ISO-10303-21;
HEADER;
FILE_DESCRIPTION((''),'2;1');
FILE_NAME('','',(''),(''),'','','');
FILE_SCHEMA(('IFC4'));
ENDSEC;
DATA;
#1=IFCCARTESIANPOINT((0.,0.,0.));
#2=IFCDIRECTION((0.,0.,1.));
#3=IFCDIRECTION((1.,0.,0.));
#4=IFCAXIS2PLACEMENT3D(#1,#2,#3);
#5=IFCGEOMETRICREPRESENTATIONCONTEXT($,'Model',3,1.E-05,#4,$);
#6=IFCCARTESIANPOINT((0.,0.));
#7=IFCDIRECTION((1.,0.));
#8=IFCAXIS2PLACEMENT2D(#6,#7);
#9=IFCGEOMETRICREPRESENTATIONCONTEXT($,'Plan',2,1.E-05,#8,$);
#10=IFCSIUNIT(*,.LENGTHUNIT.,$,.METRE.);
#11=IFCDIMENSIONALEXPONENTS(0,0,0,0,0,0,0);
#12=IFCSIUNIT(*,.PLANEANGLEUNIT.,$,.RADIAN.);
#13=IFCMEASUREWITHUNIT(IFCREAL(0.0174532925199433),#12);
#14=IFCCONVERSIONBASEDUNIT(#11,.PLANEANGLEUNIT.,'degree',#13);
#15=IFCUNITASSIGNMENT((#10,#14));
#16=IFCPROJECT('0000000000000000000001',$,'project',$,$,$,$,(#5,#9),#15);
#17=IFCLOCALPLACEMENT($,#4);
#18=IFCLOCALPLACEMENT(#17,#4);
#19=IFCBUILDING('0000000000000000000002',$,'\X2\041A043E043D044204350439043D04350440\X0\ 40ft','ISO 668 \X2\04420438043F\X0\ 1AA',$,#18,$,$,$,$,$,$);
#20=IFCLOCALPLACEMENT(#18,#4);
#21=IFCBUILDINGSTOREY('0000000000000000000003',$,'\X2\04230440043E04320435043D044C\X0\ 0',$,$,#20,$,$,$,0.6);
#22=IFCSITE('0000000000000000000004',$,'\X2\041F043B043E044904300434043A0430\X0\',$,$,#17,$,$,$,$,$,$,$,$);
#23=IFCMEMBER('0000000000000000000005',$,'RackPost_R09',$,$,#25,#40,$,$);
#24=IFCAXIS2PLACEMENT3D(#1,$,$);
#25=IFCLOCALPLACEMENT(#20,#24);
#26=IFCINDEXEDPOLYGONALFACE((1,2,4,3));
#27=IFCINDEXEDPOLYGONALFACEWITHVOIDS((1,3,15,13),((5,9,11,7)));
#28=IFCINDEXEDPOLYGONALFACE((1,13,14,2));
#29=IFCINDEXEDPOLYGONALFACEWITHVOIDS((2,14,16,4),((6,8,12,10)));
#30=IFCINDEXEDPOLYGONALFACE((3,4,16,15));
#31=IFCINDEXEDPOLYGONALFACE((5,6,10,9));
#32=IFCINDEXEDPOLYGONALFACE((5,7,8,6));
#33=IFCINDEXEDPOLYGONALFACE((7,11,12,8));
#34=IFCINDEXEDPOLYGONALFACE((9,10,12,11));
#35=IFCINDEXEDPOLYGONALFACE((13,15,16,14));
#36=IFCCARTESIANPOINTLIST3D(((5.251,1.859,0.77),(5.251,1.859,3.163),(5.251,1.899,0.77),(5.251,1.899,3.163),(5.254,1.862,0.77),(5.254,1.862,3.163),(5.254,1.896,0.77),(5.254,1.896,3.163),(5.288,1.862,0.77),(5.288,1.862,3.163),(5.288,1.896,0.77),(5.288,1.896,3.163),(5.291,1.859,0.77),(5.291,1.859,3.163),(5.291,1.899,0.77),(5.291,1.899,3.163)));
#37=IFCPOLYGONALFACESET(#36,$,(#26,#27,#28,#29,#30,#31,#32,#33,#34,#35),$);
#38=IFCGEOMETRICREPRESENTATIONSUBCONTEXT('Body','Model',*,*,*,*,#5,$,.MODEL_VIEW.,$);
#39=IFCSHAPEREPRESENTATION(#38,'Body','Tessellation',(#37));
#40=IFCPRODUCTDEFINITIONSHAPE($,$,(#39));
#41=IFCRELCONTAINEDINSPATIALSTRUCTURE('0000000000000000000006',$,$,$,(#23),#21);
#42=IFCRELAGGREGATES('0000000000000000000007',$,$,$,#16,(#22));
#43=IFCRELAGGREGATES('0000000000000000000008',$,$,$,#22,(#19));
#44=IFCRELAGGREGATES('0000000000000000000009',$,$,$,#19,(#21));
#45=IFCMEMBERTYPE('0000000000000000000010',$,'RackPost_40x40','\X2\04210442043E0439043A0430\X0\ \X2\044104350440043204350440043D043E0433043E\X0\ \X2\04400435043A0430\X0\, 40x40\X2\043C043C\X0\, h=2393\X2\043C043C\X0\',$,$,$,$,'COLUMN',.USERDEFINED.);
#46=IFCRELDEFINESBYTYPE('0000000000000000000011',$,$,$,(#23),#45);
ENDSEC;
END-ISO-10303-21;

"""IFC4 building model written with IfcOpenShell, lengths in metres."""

from ifc_helpers import new_model, entity, si_unit, converted_unit, frame, origin_with_axes, origin_2d_with_axis, place, context, subcontext, project, spatial, hollow_rectangle, extrude, type_object, element, save


model = new_model("IFC4")

# Units and contexts
model_context = context("Model", 3, precision=1e-05, world=origin_with_axes())
plan_context = context("Plan", 2, precision=1e-05, world=origin_2d_with_axis())
body_context = subcontext(model_context, "Body", "Model", "MODEL_VIEW")
ifc_project = project(units=[si_unit("LENGTHUNIT", "METRE"), converted_unit("PLANEANGLEUNIT", "degree", entity("IfcReal", 0.0174532925199433), si_unit("PLANEANGLEUNIT", "RADIAN"), dimensions=[0, 0, 0, 0, 0, 0, 0])], contexts=[model_context, plan_context])

# Site, building, storey
site_placement = place(None, origin_with_axes())
site = spatial("IfcSite", under=ifc_project, at=site_placement, Name="Площадка")
building_placement = place(site_placement, origin_with_axes())
building = spatial("IfcBuilding", under=site, at=building_placement, Name="Контейнер 40ft", Description="ISO 668 тип 1AA")
storey_placement = place(building_placement, origin_with_axes())
storey = spatial("IfcBuildingStorey", under=building, at=storey_placement, Name="Уровень 0", Elevation=0.6)

# Member
member_type = type_object("IfcMemberType", Name="RackPost_40x40", Description="Стойка серверного река, 40x40мм, h=2393мм", ElementType="COLUMN", PredefinedType="USERDEFINED")
for number, where, z_axis, x_axis, name in (
    (1, (5.271, 1.879, 0.77), (0.0, 0.0, 1.0), (1.0, 0.0, 0.0), "RackPost_R09"),
):
    element("IfcMember", number, at=place(storey_placement, frame(where, z_axis=z_axis, x_axis=x_axis)), inside=storey, type_object=member_type, Name=name, context=body_context, shape_type="SweptSolid", body=[
        extrude(hollow_rectangle(XDim=0.04, YDim=0.04, WallThickness=0.003), origin_with_axes(), (0.0, 0.0, 1.0), 2.393),
    ])

save(model, "model.ifc")
